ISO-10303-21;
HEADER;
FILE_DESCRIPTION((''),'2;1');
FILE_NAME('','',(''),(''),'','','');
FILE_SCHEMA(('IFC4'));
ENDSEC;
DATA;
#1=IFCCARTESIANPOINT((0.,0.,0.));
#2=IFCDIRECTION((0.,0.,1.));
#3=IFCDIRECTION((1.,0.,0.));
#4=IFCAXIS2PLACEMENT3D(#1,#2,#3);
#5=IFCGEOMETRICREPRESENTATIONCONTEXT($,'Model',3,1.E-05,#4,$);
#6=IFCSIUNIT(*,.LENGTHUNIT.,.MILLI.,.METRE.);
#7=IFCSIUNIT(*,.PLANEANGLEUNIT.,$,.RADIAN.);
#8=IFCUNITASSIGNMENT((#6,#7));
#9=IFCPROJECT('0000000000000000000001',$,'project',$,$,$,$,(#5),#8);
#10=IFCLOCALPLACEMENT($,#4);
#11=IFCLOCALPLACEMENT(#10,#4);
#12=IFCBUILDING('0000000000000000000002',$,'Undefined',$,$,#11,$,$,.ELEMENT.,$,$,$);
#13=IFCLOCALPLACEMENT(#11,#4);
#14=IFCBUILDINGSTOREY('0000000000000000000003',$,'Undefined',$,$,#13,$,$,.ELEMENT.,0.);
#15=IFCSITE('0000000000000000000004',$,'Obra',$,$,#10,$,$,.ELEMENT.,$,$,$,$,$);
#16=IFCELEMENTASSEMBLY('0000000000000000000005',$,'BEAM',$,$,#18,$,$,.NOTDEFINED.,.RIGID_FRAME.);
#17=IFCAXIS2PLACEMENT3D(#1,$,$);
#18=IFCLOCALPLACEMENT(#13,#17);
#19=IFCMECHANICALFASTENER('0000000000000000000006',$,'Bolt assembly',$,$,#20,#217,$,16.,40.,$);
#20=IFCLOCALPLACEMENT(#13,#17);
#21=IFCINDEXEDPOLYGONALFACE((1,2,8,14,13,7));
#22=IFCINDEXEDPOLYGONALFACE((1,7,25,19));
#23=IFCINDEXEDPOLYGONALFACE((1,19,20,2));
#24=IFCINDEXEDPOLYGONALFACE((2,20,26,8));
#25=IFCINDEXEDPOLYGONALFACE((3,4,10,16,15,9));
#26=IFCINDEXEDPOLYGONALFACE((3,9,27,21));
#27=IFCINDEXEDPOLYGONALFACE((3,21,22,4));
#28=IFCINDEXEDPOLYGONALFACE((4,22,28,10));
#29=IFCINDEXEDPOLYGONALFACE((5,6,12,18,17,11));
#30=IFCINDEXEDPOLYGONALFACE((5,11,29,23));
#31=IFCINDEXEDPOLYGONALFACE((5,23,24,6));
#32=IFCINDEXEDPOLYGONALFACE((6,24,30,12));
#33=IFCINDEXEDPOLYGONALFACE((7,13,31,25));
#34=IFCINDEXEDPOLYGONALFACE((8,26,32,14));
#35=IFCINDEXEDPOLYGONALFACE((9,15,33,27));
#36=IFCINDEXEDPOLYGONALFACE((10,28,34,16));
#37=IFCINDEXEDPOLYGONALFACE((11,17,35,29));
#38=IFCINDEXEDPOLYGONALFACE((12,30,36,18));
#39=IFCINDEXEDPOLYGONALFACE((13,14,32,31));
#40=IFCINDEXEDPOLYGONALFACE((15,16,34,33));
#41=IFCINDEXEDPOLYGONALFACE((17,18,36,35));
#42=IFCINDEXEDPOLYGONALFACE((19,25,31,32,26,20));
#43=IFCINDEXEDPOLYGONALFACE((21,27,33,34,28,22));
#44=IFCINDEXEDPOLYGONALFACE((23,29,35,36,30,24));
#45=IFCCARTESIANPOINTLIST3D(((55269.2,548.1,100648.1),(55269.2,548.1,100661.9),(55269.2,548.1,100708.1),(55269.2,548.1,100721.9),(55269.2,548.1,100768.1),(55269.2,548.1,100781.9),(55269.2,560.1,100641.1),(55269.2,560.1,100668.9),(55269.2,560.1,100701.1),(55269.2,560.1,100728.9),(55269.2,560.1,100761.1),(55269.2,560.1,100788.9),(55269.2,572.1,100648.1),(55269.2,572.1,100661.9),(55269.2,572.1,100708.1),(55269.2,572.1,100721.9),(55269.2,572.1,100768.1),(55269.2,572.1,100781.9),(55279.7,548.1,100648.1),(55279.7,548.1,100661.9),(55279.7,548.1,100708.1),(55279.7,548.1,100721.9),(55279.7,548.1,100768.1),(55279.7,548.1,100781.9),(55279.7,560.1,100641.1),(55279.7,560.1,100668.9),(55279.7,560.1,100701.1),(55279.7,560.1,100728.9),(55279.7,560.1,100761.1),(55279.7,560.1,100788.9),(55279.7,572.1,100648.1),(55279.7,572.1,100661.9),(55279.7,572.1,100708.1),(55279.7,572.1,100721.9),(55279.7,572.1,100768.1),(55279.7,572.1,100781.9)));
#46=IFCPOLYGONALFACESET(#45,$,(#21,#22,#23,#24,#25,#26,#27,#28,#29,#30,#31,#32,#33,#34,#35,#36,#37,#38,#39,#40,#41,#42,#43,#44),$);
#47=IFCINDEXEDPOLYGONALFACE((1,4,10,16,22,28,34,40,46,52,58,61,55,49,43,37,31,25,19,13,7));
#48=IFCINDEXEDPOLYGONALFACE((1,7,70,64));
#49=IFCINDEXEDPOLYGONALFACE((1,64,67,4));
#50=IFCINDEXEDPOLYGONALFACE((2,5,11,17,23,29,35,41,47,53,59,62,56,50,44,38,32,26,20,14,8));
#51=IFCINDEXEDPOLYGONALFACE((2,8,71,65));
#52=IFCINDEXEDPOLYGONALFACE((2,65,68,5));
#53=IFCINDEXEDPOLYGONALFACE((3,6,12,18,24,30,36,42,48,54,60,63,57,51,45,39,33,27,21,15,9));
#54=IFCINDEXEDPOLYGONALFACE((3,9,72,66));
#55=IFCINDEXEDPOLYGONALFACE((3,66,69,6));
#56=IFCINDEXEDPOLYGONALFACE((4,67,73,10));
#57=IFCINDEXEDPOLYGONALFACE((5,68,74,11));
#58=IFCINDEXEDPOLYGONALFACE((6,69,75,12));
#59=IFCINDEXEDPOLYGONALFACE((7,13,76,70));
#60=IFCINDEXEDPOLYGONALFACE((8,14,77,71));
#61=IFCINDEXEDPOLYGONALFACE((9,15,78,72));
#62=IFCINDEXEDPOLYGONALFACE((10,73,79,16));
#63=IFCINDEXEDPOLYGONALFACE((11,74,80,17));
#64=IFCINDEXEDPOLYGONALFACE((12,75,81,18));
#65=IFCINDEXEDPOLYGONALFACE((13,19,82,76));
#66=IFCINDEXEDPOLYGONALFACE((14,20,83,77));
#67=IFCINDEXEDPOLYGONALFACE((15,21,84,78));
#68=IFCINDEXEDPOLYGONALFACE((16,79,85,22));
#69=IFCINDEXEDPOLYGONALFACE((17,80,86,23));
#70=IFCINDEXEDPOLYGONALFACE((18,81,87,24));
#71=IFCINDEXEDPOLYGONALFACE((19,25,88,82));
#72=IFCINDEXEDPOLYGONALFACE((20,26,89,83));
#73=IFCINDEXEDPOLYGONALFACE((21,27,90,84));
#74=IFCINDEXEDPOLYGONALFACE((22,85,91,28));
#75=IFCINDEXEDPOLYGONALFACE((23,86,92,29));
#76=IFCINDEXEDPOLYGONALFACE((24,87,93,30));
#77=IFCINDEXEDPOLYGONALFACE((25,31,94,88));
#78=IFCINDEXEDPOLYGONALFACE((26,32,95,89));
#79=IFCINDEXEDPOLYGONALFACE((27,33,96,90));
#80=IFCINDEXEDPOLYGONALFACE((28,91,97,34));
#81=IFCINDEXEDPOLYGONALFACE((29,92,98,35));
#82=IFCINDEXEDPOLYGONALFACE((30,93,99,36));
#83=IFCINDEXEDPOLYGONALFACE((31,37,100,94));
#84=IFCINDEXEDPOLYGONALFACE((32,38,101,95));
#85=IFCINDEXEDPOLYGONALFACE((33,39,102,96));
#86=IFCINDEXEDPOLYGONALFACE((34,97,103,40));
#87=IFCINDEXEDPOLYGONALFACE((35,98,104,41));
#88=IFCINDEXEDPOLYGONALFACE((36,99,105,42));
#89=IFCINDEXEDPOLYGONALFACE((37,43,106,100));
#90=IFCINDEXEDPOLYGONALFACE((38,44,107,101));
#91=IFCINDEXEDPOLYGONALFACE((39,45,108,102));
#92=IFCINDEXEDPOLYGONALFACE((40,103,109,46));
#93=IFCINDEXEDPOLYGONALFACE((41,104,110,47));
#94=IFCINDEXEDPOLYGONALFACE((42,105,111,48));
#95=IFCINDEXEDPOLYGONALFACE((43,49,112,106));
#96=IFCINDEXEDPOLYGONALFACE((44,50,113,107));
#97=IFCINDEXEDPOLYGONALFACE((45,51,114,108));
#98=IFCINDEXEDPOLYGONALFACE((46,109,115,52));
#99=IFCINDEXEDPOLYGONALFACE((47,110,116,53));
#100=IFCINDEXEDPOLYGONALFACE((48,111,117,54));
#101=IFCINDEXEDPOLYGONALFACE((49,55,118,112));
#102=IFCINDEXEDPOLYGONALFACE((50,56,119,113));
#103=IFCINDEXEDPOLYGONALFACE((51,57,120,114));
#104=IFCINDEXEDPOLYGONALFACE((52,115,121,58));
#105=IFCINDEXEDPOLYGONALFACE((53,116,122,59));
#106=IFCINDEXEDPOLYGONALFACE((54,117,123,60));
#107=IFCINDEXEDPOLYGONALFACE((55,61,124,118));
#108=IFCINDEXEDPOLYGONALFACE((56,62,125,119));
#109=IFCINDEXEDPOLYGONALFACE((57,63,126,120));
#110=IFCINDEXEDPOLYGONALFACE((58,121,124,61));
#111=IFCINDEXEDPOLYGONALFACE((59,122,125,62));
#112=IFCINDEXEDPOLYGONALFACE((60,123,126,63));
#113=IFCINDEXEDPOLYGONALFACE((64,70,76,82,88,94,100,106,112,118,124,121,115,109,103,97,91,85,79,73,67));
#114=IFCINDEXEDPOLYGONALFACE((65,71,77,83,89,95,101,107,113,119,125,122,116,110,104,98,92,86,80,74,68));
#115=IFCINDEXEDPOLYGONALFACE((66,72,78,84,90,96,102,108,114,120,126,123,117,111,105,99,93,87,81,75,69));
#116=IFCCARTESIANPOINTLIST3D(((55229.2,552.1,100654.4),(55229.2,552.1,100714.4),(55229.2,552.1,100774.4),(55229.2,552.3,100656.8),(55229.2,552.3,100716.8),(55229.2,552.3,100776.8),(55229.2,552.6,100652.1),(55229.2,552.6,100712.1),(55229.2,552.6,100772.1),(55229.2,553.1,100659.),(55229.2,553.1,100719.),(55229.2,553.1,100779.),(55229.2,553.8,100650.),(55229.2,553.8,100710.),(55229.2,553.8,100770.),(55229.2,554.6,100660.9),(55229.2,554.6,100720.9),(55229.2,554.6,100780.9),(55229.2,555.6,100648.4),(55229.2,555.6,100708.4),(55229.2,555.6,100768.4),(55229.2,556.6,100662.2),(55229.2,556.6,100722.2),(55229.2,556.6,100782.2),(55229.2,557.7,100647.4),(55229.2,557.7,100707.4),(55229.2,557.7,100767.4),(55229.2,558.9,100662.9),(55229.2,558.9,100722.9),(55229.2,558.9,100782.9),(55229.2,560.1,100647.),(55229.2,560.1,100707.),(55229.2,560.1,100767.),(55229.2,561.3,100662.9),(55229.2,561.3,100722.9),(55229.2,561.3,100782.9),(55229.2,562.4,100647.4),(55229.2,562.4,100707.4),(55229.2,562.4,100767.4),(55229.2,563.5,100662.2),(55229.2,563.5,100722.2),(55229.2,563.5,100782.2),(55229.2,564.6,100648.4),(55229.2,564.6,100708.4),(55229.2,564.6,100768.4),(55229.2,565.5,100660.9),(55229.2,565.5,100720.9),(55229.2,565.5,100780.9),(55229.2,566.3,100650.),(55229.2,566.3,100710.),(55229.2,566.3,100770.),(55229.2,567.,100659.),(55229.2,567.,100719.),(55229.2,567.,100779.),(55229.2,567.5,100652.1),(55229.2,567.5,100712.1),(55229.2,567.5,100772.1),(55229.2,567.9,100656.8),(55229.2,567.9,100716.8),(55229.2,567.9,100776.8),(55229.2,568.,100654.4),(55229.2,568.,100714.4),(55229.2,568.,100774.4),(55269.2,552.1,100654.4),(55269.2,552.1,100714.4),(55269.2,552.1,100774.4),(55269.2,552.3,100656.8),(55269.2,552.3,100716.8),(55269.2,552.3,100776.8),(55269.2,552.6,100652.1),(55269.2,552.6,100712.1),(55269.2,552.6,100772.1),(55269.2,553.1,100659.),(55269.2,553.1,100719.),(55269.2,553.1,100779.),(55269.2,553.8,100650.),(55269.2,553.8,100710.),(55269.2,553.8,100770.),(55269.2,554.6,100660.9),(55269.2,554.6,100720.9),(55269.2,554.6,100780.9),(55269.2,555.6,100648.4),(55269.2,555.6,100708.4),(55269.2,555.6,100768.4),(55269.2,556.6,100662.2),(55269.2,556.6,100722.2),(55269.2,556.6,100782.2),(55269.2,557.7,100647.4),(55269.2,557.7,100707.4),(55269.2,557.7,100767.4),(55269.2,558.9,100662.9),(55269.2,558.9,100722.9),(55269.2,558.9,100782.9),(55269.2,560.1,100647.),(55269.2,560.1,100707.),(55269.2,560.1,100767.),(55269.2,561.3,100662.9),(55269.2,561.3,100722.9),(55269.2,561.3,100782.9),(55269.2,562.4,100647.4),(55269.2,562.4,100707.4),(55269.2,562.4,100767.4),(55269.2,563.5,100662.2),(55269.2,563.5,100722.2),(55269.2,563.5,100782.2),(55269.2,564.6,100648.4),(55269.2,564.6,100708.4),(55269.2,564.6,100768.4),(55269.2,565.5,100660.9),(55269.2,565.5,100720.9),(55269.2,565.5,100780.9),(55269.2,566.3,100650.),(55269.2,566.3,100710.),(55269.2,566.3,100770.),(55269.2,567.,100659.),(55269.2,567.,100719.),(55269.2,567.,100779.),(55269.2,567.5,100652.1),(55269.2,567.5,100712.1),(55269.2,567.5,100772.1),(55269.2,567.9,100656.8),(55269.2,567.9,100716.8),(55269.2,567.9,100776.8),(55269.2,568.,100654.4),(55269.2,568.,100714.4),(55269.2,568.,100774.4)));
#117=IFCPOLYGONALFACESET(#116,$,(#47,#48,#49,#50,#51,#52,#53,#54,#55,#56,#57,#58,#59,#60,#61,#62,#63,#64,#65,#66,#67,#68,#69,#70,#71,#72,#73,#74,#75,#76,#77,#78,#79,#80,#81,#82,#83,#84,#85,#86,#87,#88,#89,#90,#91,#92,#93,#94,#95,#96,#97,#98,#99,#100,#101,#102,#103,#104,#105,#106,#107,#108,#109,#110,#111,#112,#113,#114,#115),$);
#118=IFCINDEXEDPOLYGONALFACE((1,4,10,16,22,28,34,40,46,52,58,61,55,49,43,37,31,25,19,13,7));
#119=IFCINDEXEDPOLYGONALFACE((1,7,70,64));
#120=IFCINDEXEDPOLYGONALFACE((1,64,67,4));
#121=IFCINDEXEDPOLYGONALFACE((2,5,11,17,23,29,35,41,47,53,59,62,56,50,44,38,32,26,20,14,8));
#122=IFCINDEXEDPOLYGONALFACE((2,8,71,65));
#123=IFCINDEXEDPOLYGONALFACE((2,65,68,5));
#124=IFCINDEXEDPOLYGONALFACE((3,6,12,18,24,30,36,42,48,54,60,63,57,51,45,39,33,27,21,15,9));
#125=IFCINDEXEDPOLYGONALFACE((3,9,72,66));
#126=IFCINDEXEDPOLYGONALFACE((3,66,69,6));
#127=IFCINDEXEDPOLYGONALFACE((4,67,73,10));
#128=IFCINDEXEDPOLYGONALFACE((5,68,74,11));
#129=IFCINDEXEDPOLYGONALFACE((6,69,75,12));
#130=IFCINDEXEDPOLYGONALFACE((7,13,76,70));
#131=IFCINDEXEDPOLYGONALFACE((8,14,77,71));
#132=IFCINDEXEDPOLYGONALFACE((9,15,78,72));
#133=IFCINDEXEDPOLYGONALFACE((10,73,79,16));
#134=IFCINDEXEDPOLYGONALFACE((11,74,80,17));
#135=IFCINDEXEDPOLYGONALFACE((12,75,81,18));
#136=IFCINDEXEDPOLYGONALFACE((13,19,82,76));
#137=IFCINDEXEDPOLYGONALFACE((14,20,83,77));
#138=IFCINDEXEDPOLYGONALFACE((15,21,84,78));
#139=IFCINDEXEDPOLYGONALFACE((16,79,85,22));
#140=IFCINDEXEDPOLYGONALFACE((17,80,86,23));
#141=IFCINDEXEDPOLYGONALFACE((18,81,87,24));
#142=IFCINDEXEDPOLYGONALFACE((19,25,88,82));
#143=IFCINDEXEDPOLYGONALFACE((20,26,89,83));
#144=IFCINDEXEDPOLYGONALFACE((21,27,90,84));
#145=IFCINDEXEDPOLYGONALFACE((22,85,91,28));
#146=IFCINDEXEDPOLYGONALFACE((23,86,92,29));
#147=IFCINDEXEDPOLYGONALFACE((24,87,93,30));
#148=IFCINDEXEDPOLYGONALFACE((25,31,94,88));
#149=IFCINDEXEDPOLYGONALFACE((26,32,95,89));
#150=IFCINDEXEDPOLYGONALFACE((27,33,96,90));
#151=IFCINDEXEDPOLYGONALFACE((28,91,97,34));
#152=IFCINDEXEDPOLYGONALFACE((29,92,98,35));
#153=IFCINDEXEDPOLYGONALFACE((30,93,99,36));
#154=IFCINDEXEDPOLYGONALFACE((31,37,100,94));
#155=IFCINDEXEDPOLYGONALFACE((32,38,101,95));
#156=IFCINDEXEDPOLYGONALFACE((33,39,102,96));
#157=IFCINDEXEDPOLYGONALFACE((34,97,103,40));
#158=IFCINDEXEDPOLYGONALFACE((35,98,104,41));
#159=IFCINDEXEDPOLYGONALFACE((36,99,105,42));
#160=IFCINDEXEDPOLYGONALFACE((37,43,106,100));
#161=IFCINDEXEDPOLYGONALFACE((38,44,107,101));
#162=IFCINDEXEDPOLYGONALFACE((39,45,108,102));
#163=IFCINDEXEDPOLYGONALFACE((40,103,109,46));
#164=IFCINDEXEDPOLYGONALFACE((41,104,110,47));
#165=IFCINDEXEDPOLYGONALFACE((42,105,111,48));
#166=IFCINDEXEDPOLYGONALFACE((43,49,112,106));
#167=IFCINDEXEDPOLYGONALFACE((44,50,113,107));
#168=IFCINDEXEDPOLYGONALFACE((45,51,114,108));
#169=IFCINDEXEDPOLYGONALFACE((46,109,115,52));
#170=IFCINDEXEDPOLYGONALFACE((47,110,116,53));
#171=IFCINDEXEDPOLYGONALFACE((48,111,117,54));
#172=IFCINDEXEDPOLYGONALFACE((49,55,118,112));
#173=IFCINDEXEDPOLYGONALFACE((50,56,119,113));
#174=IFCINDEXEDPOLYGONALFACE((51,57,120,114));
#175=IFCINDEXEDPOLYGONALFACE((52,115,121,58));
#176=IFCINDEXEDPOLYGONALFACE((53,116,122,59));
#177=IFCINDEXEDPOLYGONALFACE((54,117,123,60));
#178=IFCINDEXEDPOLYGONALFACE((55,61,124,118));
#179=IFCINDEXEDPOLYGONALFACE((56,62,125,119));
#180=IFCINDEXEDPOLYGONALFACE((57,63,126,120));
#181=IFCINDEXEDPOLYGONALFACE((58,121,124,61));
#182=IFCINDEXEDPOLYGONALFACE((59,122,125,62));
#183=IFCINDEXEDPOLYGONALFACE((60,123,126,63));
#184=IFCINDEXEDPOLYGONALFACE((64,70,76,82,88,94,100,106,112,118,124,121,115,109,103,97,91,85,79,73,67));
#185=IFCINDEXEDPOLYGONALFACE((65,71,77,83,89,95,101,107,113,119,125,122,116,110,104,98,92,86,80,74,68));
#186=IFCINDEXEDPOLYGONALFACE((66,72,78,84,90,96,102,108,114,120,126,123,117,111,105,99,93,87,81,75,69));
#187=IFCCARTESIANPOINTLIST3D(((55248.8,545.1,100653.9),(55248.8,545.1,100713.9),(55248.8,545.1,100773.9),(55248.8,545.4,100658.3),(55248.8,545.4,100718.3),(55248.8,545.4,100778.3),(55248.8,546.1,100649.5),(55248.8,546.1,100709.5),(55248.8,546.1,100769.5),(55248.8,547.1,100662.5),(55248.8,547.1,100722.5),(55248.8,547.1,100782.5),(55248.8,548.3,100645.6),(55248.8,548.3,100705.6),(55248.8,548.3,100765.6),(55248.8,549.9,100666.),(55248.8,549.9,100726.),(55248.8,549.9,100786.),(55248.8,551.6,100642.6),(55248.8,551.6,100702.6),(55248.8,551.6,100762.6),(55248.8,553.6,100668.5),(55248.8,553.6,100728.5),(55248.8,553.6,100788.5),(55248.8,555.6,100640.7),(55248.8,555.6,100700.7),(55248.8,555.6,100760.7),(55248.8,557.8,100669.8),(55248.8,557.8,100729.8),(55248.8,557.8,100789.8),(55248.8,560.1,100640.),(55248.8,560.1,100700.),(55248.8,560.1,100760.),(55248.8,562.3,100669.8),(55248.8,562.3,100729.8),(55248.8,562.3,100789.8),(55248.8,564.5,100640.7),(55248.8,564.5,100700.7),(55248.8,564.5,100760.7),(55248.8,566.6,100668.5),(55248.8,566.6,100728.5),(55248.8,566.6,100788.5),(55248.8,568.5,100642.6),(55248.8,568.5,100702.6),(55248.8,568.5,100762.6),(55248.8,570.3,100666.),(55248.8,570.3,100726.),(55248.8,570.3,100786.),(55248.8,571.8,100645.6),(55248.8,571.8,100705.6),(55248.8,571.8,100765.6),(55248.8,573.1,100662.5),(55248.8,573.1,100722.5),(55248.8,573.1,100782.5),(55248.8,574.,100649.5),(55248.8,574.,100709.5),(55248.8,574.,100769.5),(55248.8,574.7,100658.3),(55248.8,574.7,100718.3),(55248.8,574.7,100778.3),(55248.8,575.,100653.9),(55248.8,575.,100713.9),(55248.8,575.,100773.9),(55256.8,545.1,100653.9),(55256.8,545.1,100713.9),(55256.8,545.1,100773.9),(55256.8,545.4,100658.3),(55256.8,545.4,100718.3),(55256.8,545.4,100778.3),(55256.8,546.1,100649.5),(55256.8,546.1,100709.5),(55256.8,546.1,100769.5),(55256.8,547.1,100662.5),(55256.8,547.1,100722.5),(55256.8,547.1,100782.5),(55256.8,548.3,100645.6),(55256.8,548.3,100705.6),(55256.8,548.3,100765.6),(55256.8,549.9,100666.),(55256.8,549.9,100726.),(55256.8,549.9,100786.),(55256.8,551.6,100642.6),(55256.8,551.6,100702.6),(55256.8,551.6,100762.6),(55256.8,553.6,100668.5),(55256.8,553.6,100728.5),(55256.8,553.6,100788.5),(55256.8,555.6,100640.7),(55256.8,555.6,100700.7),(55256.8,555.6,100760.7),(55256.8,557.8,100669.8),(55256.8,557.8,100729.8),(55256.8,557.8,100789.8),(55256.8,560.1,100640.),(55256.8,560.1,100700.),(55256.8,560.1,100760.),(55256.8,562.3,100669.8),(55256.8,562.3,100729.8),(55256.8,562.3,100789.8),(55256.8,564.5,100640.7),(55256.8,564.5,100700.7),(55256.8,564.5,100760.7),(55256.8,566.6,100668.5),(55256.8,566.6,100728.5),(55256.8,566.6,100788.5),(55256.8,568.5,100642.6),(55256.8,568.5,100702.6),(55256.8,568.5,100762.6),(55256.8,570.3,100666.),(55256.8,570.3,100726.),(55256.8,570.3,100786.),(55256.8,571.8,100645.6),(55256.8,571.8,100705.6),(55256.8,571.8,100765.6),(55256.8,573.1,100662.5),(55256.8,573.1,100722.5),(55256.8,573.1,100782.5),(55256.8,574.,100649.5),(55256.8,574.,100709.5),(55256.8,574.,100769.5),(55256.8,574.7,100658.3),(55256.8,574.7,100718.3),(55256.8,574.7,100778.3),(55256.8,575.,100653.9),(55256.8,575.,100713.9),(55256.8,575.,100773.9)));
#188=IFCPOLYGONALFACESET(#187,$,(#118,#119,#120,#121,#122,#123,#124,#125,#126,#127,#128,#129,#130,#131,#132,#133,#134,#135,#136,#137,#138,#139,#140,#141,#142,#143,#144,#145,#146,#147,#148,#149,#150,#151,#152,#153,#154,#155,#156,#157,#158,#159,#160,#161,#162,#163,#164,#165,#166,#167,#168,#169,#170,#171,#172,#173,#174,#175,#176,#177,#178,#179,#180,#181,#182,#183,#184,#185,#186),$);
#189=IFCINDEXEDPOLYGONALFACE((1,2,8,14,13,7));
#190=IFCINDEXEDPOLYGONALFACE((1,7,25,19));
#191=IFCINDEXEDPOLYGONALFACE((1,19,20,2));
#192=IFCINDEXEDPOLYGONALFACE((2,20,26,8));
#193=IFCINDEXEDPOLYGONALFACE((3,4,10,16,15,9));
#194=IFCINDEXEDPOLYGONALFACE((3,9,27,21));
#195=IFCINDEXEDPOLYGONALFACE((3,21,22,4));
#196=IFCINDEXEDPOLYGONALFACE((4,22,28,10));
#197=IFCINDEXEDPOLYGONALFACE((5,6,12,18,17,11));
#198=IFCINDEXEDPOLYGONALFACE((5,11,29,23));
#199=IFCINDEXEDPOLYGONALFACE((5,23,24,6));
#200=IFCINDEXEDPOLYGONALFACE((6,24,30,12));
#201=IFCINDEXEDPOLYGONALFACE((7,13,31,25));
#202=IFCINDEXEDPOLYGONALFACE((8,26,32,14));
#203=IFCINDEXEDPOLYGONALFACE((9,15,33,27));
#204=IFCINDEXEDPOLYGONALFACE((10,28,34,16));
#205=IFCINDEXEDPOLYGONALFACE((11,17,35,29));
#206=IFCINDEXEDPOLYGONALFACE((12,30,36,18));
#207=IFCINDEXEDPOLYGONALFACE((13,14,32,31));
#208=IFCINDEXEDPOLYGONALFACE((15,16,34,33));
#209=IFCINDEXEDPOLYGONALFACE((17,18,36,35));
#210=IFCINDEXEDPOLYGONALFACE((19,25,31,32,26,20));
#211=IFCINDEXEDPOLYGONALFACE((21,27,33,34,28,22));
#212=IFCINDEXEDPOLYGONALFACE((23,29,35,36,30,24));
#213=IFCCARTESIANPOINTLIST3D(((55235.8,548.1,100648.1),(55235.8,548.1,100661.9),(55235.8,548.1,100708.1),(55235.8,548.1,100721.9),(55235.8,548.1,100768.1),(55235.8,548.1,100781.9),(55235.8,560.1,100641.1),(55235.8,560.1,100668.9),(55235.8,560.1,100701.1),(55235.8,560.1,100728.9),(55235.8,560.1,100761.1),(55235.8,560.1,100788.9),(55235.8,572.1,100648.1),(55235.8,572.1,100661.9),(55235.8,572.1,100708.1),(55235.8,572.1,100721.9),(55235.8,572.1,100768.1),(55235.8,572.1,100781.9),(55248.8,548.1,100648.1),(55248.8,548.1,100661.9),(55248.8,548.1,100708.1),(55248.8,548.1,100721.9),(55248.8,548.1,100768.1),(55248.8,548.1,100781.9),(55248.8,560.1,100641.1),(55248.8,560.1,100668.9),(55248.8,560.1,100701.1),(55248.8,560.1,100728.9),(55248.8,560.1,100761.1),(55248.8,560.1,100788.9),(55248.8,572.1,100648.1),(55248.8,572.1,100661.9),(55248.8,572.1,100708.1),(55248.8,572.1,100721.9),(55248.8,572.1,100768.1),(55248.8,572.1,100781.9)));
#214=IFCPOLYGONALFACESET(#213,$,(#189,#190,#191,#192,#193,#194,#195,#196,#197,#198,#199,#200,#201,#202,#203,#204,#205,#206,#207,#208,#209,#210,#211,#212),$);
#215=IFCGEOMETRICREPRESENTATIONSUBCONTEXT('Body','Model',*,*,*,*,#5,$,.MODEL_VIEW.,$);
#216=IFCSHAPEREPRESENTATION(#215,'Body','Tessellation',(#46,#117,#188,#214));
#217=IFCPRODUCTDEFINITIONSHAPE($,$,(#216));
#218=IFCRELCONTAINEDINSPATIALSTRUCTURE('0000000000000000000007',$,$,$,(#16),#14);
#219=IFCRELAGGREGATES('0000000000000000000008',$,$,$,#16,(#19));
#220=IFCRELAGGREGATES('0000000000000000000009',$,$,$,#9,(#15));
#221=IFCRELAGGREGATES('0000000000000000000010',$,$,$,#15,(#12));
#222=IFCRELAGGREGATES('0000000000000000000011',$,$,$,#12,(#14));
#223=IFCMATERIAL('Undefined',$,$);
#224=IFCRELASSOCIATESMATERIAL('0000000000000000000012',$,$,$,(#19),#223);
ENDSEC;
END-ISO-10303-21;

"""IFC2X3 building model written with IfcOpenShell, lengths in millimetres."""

from ifc_helpers import new_model, si_unit, frame, origin_with_axes, origin_2d_with_axis, place, context, subcontext, project, spatial, polyline, circle, outline, extrude, source, transform, mapped, material, element, aggregate, save


model = new_model("IFC2X3")

# Units and contexts
model_context = context("Model", 3, precision=1e-05, world=origin_with_axes())
body_context = subcontext(model_context, "Body", "Model", "MODEL_VIEW")
ifc_project = project(units=[si_unit("LENGTHUNIT", "METRE", prefix="MILLI"), si_unit("PLANEANGLEUNIT", "RADIAN")], contexts=[model_context])

# Site, building, storey
site_placement = place(None, origin_with_axes())
site = spatial("IfcSite", under=ifc_project, at=site_placement, Name="Obra", CompositionType="ELEMENT")
building_placement = place(site_placement, origin_with_axes())
building = spatial("IfcBuilding", under=site, at=building_placement, Name="Undefined", CompositionType="ELEMENT")
storey_placement = place(building_placement, origin_with_axes())
storey = spatial("IfcBuildingStorey", under=building, at=storey_placement, Name="Undefined", CompositionType="ELEMENT", Elevation=0.0)

# Shared definitions
ifc_material_1 = material(Name="Undefined")

# Element assembly, mechanical fastener
shared_shape_1 = source(origin_with_axes(), body_context, "Body", "SweptSolid", [
    extrude(outline(polyline([(13.9, 0.0), (6.9, 12.0), (-6.9, 12.0), (-13.9, 0.0), (-6.9, -12.0), (6.9, -12.0), (13.9, 0.0)])), frame((0.0, -19.7, 0.0), z_axis=(0.0, 1.0, 0.0), x_axis=(1.0, 0.0, 0.0)), (0.0, 0.0, 1.0), 10.6),
    extrude(circle(Radius=8.0, at=origin_2d_with_axis()), frame((0.0, -9.1, 0.0), z_axis=(0.0, 1.0, 0.0), x_axis=(1.0, 0.0, 0.0)), (0.0, 0.0, 1.0), 40.0),
    extrude(circle(Radius=15.0, at=origin_2d_with_axis()), frame((0.0, 3.3, 0.0), z_axis=(0.0, 1.0, 0.0), x_axis=(1.0, 0.0, 0.0)), (0.0, 0.0, 1.0), 8.0),
    extrude(outline(polyline([(13.9, 0.0), (6.9, 12.0), (-6.9, 12.0), (-13.9, 0.0), (-6.9, -12.0), (6.9, -12.0), (13.9, 0.0)])), frame((0.0, 11.3, 0.0), z_axis=(0.0, 1.0, 0.0), x_axis=(1.0, 0.0, 0.0)), (0.0, 0.0, 1.0), 13.0),
])
assembly_1_placement = place(storey_placement, origin_with_axes())
assembly_1 = element("IfcElementAssembly", 1, at=assembly_1_placement, inside=storey, Name="BEAM", AssemblyPlace="NOTDEFINED", PredefinedType="RIGID_FRAME")
mechanical_fastener_1_placement = place(assembly_1_placement, frame((55260.1, 510.1, 100835.0), z_axis=(-0.000002, 1.0, 0.0), x_axis=(0.0, 0.0, -1.0)))
mechanical_fastener_1 = element("IfcMechanicalFastener", 2, at=mechanical_fastener_1_placement, material=ifc_material_1, Name="Bolt assembly", NominalDiameter=16.0, NominalLength=40.0, context=body_context, shape_type="MappedRepresentation", body=[
    mapped(shared_shape_1, transform((60.0, 0.0, 50.0))),
    mapped(shared_shape_1, transform((120.0, 0.0, 50.0))),
    mapped(shared_shape_1, transform((180.0, 0.0, 50.0))),
])

aggregate(assembly_1, [mechanical_fastener_1])

save(model, "model.ifc")
